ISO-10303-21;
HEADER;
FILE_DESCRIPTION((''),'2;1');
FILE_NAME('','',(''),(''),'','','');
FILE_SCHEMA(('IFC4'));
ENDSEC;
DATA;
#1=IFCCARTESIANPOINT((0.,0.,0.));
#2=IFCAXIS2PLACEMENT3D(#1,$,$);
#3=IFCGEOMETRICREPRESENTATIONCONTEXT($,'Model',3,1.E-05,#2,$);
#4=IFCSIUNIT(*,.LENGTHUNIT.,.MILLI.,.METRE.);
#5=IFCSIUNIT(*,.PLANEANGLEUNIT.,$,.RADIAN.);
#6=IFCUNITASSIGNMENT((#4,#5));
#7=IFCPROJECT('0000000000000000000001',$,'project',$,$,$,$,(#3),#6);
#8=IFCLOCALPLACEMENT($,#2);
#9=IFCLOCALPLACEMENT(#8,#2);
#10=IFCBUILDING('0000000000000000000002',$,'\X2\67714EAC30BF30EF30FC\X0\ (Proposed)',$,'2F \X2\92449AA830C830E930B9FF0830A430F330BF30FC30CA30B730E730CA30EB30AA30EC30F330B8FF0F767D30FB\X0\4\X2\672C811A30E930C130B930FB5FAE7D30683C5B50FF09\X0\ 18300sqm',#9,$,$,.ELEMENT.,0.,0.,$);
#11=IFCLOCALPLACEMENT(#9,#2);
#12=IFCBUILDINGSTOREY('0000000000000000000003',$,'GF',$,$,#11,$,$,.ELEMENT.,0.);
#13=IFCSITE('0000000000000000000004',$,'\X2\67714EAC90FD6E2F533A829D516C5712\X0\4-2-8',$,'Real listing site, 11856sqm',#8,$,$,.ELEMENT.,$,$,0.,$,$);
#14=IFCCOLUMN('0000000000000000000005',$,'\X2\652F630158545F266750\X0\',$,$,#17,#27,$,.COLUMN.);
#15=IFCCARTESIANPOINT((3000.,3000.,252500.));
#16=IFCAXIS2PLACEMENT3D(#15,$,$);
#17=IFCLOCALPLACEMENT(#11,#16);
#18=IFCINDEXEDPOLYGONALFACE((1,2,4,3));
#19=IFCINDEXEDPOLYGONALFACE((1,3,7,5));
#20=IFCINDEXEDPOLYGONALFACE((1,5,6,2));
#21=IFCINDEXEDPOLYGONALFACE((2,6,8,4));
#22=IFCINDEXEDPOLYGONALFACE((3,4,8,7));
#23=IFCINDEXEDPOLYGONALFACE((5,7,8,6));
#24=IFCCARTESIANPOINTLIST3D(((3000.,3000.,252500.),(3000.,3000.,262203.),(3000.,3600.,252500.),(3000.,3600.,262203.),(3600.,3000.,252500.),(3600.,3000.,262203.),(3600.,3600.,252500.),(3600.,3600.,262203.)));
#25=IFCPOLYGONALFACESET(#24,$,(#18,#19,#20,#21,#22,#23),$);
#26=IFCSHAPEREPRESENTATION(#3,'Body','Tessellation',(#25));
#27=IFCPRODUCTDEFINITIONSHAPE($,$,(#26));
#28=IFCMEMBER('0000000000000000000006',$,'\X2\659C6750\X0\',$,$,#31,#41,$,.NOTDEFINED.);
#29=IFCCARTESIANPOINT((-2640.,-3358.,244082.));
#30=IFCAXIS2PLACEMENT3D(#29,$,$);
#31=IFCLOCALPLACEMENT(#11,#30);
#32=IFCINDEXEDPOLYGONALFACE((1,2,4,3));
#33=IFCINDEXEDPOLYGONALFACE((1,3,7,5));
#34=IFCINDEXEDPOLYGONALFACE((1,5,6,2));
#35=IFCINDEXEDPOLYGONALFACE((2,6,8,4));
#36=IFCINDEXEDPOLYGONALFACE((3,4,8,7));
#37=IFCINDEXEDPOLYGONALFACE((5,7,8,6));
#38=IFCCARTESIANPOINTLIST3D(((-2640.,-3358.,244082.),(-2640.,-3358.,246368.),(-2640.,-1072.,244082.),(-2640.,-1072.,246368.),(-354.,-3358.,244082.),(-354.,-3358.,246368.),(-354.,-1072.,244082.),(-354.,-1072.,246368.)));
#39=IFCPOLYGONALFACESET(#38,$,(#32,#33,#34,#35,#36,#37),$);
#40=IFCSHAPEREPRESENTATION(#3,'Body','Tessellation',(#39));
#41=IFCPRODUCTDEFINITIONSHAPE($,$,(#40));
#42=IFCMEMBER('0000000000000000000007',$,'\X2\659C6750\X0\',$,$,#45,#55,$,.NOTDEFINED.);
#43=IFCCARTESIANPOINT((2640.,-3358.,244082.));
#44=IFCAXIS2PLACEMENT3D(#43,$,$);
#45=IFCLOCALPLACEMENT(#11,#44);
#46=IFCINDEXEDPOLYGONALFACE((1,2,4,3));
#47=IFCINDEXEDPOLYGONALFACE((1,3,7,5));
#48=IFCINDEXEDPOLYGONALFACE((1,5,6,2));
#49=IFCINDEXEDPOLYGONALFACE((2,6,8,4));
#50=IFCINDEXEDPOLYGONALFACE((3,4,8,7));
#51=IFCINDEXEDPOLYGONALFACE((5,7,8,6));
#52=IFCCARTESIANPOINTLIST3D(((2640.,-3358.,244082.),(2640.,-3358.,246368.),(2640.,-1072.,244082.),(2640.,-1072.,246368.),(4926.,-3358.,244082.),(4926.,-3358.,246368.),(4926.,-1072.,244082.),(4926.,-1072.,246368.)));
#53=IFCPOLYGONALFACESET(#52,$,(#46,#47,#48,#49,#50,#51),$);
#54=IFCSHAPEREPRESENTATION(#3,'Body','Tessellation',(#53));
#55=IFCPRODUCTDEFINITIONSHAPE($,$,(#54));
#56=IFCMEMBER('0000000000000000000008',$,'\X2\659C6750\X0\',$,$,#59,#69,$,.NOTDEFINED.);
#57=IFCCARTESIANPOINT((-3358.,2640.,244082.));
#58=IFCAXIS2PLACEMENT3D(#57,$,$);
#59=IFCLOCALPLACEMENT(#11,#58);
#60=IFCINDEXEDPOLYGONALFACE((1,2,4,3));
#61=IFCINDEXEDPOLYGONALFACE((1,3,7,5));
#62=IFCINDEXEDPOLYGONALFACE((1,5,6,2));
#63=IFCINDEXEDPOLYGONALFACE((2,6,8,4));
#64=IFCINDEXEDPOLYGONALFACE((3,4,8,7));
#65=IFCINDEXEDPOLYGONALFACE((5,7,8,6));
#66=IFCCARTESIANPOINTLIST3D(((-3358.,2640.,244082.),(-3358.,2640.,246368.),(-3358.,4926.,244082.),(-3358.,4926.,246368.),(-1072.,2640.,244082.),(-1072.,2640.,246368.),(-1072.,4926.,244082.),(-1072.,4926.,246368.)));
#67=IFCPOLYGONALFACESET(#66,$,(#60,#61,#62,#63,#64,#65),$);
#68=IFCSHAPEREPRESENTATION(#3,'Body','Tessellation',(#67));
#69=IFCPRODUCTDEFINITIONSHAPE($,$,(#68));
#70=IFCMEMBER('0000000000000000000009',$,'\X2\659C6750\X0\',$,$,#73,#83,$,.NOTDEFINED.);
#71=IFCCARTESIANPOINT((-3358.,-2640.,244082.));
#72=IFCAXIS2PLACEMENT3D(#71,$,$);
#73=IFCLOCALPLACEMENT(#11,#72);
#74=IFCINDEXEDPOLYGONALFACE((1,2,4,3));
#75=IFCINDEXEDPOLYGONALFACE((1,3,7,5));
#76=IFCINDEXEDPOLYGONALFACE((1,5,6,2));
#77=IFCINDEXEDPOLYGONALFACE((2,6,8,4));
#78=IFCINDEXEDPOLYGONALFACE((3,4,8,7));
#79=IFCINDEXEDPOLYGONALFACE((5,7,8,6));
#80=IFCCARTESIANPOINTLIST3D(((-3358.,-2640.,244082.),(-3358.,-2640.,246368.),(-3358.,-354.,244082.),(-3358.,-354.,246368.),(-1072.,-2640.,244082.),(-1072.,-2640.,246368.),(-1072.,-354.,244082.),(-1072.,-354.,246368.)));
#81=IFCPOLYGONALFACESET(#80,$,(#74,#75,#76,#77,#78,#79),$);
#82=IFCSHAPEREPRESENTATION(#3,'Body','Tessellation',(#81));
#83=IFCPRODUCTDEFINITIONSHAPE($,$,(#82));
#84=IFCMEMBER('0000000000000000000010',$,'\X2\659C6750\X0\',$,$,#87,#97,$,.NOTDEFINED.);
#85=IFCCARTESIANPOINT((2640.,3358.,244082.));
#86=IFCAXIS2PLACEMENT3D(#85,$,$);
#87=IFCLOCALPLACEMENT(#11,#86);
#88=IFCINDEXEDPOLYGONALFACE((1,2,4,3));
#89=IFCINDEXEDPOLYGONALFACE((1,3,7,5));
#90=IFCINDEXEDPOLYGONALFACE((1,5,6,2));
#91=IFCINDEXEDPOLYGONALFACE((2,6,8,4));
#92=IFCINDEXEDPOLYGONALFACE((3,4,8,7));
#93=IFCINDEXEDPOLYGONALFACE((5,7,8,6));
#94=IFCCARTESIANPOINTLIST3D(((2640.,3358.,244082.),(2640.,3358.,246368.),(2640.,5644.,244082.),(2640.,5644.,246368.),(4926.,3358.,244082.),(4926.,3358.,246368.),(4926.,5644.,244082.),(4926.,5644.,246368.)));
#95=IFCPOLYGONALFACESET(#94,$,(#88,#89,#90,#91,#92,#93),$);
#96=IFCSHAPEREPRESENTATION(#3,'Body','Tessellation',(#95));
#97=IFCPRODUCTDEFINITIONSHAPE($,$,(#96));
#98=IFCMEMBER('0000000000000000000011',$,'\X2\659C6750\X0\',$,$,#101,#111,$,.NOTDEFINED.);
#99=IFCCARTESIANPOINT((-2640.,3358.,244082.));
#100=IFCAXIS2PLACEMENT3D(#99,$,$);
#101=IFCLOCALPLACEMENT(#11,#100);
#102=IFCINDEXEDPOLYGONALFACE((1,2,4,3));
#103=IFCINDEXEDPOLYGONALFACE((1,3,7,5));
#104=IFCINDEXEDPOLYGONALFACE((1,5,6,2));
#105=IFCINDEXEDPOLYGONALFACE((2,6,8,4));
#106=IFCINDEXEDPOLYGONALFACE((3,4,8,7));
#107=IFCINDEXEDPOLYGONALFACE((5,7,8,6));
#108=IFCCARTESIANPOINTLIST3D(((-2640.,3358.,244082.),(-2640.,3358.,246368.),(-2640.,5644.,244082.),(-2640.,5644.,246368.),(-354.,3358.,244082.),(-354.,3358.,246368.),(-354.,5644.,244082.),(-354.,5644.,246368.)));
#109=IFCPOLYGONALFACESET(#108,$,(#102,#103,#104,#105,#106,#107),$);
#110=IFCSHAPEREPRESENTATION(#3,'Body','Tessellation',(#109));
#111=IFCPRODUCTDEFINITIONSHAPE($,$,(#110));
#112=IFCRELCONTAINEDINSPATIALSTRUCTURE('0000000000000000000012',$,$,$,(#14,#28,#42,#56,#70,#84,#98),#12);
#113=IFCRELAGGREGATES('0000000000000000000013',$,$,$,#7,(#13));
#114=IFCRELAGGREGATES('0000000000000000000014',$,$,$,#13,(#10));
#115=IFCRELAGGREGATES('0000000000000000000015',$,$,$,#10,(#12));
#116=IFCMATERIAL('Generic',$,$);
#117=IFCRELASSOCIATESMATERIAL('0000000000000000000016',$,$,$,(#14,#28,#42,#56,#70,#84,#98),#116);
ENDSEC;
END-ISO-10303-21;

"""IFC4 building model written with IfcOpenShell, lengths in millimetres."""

from ifc_helpers import new_model, si_unit, frame, frame_2d, origin, place, context, project, spatial, rectangle, extrude, material, element, save


model = new_model("IFC4")

# Units and contexts
model_context = context("Model", 3, precision=1e-05, world=origin())
ifc_project = project(units=[si_unit("LENGTHUNIT", "METRE", prefix="MILLI"), si_unit("PLANEANGLEUNIT", "RADIAN")], contexts=[model_context])

# Site, building, storey
site_placement = place(None, origin())
site = spatial("IfcSite", under=ifc_project, at=site_placement, Name="東京都港区芝公園4-2-8", ObjectType="Real listing site, 11856sqm", CompositionType="ELEMENT", RefElevation=0.0)
building_placement = place(site_placement, origin())
building = spatial("IfcBuilding", under=site, at=building_placement, Name="東京タワー (Proposed)", ObjectType="2F 鉄骨トラス（インターナショナルオレンジ／白・4本脚ラチス・微細格子） 18300sqm", CompositionType="ELEMENT", ElevationOfRefHeight=0.0, ElevationOfTerrain=0.0)
storey_placement = place(building_placement, origin())
storey = spatial("IfcBuildingStorey", under=building, at=storey_placement, Name="GF", CompositionType="ELEMENT", Elevation=0.0)

# Column
ifc_material = material(Name="Generic")
column_placement = place(storey_placement, frame((3000.0, 3000.0, 252500.0)))
element("IfcColumn", 1, at=column_placement, inside=storey, material=ifc_material, Name="支持塔弦材", PredefinedType="COLUMN", context=model_context, shape_type="SweptSolid", body=[
    extrude(rectangle(XDim=600.0, YDim=600.0, at=frame_2d((300.0, 300.0))), frame((3000.0, 3000.0, 252500.0)), (0.0, 0.0, 1.0), 9703.0),
])

# Members
member_1_placement = place(storey_placement, frame((-2640.0, -3358.0, 244082.0)))
element("IfcMember", 2, at=member_1_placement, inside=storey, material=ifc_material, Name="斜材", PredefinedType="NOTDEFINED", context=model_context, shape_type="SweptSolid", body=[
    extrude(rectangle(XDim=2286.0, YDim=2286.0, at=frame_2d((1143.0, 1143.0))), frame((-2640.0, -3358.0, 244082.0)), (0.0, 0.0, 1.0), 2286.0),
])
member_2_placement = place(storey_placement, frame((2640.0, -3358.0, 244082.0)))
element("IfcMember", 3, at=member_2_placement, inside=storey, material=ifc_material, Name="斜材", PredefinedType="NOTDEFINED", context=model_context, shape_type="SweptSolid", body=[
    extrude(rectangle(XDim=2286.0, YDim=2286.0, at=frame_2d((1143.0, 1143.0))), frame((2640.0, -3358.0, 244082.0)), (0.0, 0.0, 1.0), 2286.0),
])
member_3_placement = place(storey_placement, frame((-3358.0, 2640.0, 244082.0)))
element("IfcMember", 4, at=member_3_placement, inside=storey, material=ifc_material, Name="斜材", PredefinedType="NOTDEFINED", context=model_context, shape_type="SweptSolid", body=[
    extrude(rectangle(XDim=2286.0, YDim=2286.0, at=frame_2d((1143.0, 1143.0))), frame((-3358.0, 2640.0, 244082.0)), (0.0, 0.0, 1.0), 2286.0),
])
member_4_placement = place(storey_placement, frame((-3358.0, -2640.0, 244082.0)))
element("IfcMember", 5, at=member_4_placement, inside=storey, material=ifc_material, Name="斜材", PredefinedType="NOTDEFINED", context=model_context, shape_type="SweptSolid", body=[
    extrude(rectangle(XDim=2286.0, YDim=2286.0, at=frame_2d((1143.0, 1143.0))), frame((-3358.0, -2640.0, 244082.0)), (0.0, 0.0, 1.0), 2286.0),
])
member_5_placement = place(storey_placement, frame((2640.0, 3358.0, 244082.0)))
element("IfcMember", 6, at=member_5_placement, inside=storey, material=ifc_material, Name="斜材", PredefinedType="NOTDEFINED", context=model_context, shape_type="SweptSolid", body=[
    extrude(rectangle(XDim=2286.0, YDim=2286.0, at=frame_2d((1143.0, 1143.0))), frame((2640.0, 3358.0, 244082.0)), (0.0, 0.0, 1.0), 2286.0),
])
member_6_placement = place(storey_placement, frame((-2640.0, 3358.0, 244082.0)))
element("IfcMember", 7, at=member_6_placement, inside=storey, material=ifc_material, Name="斜材", PredefinedType="NOTDEFINED", context=model_context, shape_type="SweptSolid", body=[
    extrude(rectangle(XDim=2286.0, YDim=2286.0, at=frame_2d((1143.0, 1143.0))), frame((-2640.0, 3358.0, 244082.0)), (0.0, 0.0, 1.0), 2286.0),
])

save(model, "model.ifc")
